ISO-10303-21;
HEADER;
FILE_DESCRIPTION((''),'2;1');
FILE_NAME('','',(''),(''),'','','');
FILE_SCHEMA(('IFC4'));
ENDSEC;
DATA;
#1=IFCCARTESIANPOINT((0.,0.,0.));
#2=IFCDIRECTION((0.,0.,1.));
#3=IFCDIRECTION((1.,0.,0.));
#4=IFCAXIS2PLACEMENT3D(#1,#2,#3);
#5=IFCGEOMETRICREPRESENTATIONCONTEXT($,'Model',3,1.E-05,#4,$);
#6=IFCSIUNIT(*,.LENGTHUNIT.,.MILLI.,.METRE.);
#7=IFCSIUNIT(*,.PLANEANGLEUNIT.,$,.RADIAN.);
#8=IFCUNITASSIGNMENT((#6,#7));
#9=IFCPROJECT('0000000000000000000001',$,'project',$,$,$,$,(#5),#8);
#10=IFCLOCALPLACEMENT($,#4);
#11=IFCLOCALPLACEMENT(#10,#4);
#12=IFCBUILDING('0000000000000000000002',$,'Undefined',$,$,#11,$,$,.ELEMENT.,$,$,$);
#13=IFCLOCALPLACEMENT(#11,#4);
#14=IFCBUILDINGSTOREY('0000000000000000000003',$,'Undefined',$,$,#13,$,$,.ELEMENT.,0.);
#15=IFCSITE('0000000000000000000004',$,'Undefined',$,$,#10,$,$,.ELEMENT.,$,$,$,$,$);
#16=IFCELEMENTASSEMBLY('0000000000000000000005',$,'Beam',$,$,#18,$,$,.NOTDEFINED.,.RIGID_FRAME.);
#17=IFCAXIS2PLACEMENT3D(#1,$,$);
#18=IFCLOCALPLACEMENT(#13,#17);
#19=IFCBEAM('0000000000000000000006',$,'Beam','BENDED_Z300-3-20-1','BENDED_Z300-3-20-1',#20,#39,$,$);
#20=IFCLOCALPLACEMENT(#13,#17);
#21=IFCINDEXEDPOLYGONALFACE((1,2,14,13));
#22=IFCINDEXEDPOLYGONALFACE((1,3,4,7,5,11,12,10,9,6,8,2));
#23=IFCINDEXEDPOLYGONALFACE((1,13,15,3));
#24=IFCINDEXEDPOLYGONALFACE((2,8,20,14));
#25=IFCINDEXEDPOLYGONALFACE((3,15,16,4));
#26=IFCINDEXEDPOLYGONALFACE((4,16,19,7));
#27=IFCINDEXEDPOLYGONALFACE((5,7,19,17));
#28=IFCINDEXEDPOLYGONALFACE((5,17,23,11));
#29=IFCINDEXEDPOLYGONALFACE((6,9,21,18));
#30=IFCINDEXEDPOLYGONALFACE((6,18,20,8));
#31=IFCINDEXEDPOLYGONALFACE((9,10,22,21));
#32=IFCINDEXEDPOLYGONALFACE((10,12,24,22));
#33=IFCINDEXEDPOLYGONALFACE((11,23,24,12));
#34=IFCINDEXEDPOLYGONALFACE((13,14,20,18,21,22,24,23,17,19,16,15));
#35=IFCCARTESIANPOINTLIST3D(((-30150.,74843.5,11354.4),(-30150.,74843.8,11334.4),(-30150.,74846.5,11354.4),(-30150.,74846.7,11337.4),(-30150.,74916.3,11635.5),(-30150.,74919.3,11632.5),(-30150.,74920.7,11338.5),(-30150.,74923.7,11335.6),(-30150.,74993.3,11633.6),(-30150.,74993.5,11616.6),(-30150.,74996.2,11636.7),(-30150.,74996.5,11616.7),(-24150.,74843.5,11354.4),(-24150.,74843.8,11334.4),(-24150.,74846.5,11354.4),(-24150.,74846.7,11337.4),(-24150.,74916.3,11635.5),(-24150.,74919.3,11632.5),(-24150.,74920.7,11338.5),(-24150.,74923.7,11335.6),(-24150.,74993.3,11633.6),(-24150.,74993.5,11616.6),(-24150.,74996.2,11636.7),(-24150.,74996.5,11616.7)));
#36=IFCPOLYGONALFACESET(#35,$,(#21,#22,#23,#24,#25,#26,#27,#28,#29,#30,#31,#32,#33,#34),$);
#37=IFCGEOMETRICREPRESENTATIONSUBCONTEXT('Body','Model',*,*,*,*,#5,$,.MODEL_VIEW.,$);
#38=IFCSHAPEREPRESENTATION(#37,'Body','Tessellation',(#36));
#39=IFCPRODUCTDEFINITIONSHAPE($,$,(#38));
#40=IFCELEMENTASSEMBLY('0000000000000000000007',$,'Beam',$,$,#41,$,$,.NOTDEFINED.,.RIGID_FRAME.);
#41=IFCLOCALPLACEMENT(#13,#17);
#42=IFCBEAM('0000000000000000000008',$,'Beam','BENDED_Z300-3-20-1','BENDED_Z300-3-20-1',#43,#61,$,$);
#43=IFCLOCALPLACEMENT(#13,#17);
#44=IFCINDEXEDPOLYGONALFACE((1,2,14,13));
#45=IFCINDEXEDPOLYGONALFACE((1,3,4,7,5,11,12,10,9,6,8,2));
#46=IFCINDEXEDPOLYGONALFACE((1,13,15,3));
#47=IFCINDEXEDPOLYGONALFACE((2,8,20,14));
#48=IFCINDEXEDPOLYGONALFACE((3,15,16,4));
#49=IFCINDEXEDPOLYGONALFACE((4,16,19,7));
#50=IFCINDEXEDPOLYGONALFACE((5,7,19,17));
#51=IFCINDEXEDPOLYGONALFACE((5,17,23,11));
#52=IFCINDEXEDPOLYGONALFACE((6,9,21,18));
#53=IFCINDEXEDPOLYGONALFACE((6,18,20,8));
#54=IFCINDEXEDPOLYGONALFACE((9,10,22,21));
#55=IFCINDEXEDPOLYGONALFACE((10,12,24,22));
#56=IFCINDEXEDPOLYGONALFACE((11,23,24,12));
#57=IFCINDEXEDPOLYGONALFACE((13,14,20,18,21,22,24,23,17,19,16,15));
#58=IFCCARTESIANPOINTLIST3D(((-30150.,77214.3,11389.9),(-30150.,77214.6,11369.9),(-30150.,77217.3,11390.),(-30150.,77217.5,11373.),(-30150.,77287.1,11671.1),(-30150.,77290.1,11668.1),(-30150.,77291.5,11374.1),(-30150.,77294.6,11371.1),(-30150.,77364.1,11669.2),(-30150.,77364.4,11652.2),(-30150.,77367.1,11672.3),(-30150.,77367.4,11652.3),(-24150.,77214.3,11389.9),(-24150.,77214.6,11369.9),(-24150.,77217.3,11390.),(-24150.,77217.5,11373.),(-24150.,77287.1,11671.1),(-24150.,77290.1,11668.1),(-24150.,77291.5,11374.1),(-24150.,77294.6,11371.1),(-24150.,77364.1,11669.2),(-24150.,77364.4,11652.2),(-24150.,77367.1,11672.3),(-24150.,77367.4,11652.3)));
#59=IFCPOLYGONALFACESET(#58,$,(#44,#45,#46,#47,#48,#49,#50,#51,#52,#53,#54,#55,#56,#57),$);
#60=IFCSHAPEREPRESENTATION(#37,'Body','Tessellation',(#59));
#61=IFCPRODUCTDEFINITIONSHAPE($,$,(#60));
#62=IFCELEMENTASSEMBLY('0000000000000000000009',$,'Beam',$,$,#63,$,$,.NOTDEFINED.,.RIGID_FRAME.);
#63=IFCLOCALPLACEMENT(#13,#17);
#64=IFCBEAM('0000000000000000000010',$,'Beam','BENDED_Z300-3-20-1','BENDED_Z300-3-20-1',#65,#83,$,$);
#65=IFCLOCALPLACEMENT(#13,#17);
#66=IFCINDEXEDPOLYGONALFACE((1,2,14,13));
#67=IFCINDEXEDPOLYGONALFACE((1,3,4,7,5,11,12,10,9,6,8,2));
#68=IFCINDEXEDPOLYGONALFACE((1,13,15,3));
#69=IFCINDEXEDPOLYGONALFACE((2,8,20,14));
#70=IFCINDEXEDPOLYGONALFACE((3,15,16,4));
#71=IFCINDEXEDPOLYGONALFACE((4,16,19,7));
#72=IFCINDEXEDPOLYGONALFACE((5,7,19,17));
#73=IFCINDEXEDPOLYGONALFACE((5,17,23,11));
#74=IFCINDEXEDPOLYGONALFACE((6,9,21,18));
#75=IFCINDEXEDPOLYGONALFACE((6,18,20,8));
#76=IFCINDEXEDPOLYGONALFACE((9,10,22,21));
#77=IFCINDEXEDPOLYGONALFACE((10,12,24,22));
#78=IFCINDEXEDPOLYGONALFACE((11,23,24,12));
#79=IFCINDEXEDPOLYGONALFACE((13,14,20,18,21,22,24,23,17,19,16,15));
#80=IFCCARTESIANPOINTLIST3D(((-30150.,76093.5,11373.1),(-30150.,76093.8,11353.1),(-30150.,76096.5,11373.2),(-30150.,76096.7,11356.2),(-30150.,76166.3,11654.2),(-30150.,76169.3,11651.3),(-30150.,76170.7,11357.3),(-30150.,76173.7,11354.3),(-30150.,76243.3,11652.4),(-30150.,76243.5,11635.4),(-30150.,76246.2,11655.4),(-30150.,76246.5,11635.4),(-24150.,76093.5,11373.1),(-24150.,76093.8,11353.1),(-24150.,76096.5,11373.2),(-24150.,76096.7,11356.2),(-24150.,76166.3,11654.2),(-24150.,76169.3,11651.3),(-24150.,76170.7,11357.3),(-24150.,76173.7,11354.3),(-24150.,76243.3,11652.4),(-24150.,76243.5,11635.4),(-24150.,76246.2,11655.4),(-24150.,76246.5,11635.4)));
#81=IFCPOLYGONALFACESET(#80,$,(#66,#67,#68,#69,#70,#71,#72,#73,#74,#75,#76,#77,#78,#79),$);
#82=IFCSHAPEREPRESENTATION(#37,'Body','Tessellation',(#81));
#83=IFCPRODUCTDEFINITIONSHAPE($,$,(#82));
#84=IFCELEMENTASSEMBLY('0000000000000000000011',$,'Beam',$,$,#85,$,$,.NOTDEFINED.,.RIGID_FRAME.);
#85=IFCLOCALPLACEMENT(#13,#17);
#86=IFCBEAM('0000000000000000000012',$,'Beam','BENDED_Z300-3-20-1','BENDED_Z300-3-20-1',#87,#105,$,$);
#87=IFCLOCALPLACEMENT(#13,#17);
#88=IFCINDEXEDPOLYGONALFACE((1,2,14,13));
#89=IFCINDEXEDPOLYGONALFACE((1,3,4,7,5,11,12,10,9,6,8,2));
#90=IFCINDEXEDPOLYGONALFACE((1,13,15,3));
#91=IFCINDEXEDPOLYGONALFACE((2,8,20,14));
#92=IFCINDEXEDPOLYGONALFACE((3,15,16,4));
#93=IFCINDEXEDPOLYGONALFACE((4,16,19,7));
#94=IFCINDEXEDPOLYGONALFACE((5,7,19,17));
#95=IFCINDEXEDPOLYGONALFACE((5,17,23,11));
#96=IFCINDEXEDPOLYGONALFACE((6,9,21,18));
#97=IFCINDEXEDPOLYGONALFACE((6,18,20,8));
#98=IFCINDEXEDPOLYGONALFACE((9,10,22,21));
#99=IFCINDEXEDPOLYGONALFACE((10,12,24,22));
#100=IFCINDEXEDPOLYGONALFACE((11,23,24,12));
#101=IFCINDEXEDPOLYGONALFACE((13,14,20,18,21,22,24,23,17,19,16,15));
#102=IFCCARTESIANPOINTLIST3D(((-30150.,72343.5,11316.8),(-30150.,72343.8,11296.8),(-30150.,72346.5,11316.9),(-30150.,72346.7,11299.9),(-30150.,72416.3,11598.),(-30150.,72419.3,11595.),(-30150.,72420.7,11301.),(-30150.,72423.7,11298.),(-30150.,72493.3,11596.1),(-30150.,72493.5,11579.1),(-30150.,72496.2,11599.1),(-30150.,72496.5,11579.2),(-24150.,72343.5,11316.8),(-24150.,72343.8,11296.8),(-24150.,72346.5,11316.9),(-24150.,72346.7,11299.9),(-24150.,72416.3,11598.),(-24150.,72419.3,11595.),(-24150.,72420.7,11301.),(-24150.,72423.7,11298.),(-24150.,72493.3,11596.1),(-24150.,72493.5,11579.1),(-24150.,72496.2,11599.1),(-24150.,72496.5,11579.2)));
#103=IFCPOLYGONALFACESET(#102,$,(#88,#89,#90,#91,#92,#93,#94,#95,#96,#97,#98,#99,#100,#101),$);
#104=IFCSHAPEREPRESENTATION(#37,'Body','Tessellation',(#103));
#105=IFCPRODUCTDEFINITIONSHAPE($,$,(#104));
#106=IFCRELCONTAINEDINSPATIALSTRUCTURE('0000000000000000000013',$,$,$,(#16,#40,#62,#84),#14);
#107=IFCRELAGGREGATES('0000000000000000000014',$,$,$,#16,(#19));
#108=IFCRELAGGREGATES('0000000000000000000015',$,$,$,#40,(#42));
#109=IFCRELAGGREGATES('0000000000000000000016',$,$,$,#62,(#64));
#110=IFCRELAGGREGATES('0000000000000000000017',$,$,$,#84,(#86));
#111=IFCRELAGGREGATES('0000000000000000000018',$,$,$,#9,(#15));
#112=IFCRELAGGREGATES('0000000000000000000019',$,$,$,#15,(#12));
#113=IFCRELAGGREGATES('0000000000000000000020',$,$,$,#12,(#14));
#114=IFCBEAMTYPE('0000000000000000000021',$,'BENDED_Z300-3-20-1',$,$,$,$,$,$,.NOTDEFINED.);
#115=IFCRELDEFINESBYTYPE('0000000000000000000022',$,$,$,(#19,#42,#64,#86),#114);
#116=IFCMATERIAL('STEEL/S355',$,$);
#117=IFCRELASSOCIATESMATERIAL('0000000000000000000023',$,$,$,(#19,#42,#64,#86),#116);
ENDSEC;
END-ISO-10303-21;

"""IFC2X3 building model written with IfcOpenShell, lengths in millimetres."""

from ifc_helpers import new_model, si_unit, frame, origin_with_axes, place, context, subcontext, project, spatial, polyline, outline, extrude, material, type_object, element, aggregate, save


model = new_model("IFC2X3")

# Units and contexts
model_context = context("Model", 3, precision=1e-05, world=origin_with_axes())
body_context = subcontext(model_context, "Body", "Model", "MODEL_VIEW")
ifc_project = project(units=[si_unit("LENGTHUNIT", "METRE", prefix="MILLI"), si_unit("PLANEANGLEUNIT", "RADIAN")], contexts=[model_context])

# Site, building, storey
site_placement = place(None, origin_with_axes())
site = spatial("IfcSite", under=ifc_project, at=site_placement, Name="Undefined", CompositionType="ELEMENT")
building_placement = place(site_placement, origin_with_axes())
building = spatial("IfcBuilding", under=site, at=building_placement, Name="Undefined", CompositionType="ELEMENT")
storey_placement = place(building_placement, origin_with_axes())
storey = spatial("IfcBuildingStorey", under=building, at=storey_placement, Name="Undefined", CompositionType="ELEMENT", Elevation=0.0)

# Element assemblies, beams
ifc_material_1 = material(Name="STEEL/S355")
beam_type_1 = type_object("IfcBeamType", Name="BENDED_Z300-3-20-1", PredefinedType="NOTDEFINED")
assembly_1_placement = place(storey_placement, origin_with_axes())
assembly_1 = element("IfcElementAssembly", 1, at=assembly_1_placement, inside=storey, Name="Beam", AssemblyPlace="NOTDEFINED", PredefinedType="RIGID_FRAME")
beam_1_placement = place(assembly_1_placement, frame((-24150.0, 74920.0, 11485.5), z_axis=(0.0, -0.014963, 0.999888), x_axis=(-1.0, 0.0, 0.0)))
beam_1 = element("IfcBeam", 2, at=beam_1_placement, type_object=beam_type_1, material=ifc_material_1, Name="Beam", Description="BENDED_Z300-3-20-1", ObjectType="BENDED_Z300-3-20-1", context=body_context, shape_type="SweptSolid", body=[
    extrude(outline(polyline([(1.5, -150.0), (-78.5, -150.0), (-78.5, -130.0), (-75.5, -130.0), (-75.5, -147.0), (-1.5, -147.0), (-1.5, 150.0), (78.5, 150.0), (78.5, 130.0), (75.5, 130.0), (75.5, 147.0), (1.5, 147.0), (1.5, -150.0)])), frame((6000.0, 0.0, 0.0), z_axis=(-1.0, 0.0, 0.0), x_axis=(0.0, -1.0, 0.0)), (0.0, 0.0, 1.0), 6000.0),
])
aggregate(assembly_1, [beam_1])
assembly_2_placement = place(storey_placement, origin_with_axes())
assembly_2 = element("IfcElementAssembly", 3, at=assembly_2_placement, inside=storey, Name="Beam", AssemblyPlace="NOTDEFINED", PredefinedType="RIGID_FRAME")
beam_2_placement = place(assembly_2_placement, frame((-24150.0, 77290.8, 11521.1), z_axis=(0.0, -0.014963, 0.999888), x_axis=(-1.0, 0.0, 0.0)))
beam_2 = element("IfcBeam", 4, at=beam_2_placement, type_object=beam_type_1, material=ifc_material_1, Name="Beam", Description="BENDED_Z300-3-20-1", ObjectType="BENDED_Z300-3-20-1", context=body_context, shape_type="SweptSolid", body=[
    extrude(outline(polyline([(1.5, -150.0), (-78.5, -150.0), (-78.5, -130.0), (-75.5, -130.0), (-75.5, -147.0), (-1.5, -147.0), (-1.5, 150.0), (78.5, 150.0), (78.5, 130.0), (75.5, 130.0), (75.5, 147.0), (1.5, 147.0), (1.5, -150.0)])), frame((6000.0, 0.0, 0.0), z_axis=(-1.0, 0.0, 0.0), x_axis=(0.0, -1.0, 0.0)), (0.0, 0.0, 1.0), 6000.0),
])
aggregate(assembly_2, [beam_2])
assembly_3_placement = place(storey_placement, origin_with_axes())
assembly_3 = element("IfcElementAssembly", 5, at=assembly_3_placement, inside=storey, Name="Beam", AssemblyPlace="NOTDEFINED", PredefinedType="RIGID_FRAME")
beam_3_placement = place(assembly_3_placement, frame((-24150.0, 76170.0, 11504.3), z_axis=(0.0, -0.014963, 0.999888), x_axis=(-1.0, 0.0, 0.0)))
beam_3 = element("IfcBeam", 6, at=beam_3_placement, type_object=beam_type_1, material=ifc_material_1, Name="Beam", Description="BENDED_Z300-3-20-1", ObjectType="BENDED_Z300-3-20-1", context=body_context, shape_type="SweptSolid", body=[
    extrude(outline(polyline([(1.5, -150.0), (-78.5, -150.0), (-78.5, -130.0), (-75.5, -130.0), (-75.5, -147.0), (-1.5, -147.0), (-1.5, 150.0), (78.5, 150.0), (78.5, 130.0), (75.5, 130.0), (75.5, 147.0), (1.5, 147.0), (1.5, -150.0)])), frame((6000.0, 0.0, 0.0), z_axis=(-1.0, 0.0, 0.0), x_axis=(0.0, -1.0, 0.0)), (0.0, 0.0, 1.0), 6000.0),
])
aggregate(assembly_3, [beam_3])
assembly_4_placement = place(storey_placement, origin_with_axes())
assembly_4 = element("IfcElementAssembly", 7, at=assembly_4_placement, inside=storey, Name="Beam", AssemblyPlace="NOTDEFINED", PredefinedType="RIGID_FRAME")
beam_4_placement = place(assembly_4_placement, frame((-24150.0, 72420.0, 11448.0), z_axis=(0.0, -0.014963, 0.999888), x_axis=(-1.0, 0.0, 0.0)))
beam_4 = element("IfcBeam", 8, at=beam_4_placement, type_object=beam_type_1, material=ifc_material_1, Name="Beam", Description="BENDED_Z300-3-20-1", ObjectType="BENDED_Z300-3-20-1", context=body_context, shape_type="SweptSolid", body=[
    extrude(outline(polyline([(1.5, -150.0), (-78.5, -150.0), (-78.5, -130.0), (-75.5, -130.0), (-75.5, -147.0), (-1.5, -147.0), (-1.5, 150.0), (78.5, 150.0), (78.5, 130.0), (75.5, 130.0), (75.5, 147.0), (1.5, 147.0), (1.5, -150.0)])), frame((6000.0, 0.0, 0.0), z_axis=(-1.0, 0.0, 0.0), x_axis=(0.0, -1.0, 0.0)), (0.0, 0.0, 1.0), 6000.0),
])
aggregate(assembly_4, [beam_4])

save(model, "model.ifc")
